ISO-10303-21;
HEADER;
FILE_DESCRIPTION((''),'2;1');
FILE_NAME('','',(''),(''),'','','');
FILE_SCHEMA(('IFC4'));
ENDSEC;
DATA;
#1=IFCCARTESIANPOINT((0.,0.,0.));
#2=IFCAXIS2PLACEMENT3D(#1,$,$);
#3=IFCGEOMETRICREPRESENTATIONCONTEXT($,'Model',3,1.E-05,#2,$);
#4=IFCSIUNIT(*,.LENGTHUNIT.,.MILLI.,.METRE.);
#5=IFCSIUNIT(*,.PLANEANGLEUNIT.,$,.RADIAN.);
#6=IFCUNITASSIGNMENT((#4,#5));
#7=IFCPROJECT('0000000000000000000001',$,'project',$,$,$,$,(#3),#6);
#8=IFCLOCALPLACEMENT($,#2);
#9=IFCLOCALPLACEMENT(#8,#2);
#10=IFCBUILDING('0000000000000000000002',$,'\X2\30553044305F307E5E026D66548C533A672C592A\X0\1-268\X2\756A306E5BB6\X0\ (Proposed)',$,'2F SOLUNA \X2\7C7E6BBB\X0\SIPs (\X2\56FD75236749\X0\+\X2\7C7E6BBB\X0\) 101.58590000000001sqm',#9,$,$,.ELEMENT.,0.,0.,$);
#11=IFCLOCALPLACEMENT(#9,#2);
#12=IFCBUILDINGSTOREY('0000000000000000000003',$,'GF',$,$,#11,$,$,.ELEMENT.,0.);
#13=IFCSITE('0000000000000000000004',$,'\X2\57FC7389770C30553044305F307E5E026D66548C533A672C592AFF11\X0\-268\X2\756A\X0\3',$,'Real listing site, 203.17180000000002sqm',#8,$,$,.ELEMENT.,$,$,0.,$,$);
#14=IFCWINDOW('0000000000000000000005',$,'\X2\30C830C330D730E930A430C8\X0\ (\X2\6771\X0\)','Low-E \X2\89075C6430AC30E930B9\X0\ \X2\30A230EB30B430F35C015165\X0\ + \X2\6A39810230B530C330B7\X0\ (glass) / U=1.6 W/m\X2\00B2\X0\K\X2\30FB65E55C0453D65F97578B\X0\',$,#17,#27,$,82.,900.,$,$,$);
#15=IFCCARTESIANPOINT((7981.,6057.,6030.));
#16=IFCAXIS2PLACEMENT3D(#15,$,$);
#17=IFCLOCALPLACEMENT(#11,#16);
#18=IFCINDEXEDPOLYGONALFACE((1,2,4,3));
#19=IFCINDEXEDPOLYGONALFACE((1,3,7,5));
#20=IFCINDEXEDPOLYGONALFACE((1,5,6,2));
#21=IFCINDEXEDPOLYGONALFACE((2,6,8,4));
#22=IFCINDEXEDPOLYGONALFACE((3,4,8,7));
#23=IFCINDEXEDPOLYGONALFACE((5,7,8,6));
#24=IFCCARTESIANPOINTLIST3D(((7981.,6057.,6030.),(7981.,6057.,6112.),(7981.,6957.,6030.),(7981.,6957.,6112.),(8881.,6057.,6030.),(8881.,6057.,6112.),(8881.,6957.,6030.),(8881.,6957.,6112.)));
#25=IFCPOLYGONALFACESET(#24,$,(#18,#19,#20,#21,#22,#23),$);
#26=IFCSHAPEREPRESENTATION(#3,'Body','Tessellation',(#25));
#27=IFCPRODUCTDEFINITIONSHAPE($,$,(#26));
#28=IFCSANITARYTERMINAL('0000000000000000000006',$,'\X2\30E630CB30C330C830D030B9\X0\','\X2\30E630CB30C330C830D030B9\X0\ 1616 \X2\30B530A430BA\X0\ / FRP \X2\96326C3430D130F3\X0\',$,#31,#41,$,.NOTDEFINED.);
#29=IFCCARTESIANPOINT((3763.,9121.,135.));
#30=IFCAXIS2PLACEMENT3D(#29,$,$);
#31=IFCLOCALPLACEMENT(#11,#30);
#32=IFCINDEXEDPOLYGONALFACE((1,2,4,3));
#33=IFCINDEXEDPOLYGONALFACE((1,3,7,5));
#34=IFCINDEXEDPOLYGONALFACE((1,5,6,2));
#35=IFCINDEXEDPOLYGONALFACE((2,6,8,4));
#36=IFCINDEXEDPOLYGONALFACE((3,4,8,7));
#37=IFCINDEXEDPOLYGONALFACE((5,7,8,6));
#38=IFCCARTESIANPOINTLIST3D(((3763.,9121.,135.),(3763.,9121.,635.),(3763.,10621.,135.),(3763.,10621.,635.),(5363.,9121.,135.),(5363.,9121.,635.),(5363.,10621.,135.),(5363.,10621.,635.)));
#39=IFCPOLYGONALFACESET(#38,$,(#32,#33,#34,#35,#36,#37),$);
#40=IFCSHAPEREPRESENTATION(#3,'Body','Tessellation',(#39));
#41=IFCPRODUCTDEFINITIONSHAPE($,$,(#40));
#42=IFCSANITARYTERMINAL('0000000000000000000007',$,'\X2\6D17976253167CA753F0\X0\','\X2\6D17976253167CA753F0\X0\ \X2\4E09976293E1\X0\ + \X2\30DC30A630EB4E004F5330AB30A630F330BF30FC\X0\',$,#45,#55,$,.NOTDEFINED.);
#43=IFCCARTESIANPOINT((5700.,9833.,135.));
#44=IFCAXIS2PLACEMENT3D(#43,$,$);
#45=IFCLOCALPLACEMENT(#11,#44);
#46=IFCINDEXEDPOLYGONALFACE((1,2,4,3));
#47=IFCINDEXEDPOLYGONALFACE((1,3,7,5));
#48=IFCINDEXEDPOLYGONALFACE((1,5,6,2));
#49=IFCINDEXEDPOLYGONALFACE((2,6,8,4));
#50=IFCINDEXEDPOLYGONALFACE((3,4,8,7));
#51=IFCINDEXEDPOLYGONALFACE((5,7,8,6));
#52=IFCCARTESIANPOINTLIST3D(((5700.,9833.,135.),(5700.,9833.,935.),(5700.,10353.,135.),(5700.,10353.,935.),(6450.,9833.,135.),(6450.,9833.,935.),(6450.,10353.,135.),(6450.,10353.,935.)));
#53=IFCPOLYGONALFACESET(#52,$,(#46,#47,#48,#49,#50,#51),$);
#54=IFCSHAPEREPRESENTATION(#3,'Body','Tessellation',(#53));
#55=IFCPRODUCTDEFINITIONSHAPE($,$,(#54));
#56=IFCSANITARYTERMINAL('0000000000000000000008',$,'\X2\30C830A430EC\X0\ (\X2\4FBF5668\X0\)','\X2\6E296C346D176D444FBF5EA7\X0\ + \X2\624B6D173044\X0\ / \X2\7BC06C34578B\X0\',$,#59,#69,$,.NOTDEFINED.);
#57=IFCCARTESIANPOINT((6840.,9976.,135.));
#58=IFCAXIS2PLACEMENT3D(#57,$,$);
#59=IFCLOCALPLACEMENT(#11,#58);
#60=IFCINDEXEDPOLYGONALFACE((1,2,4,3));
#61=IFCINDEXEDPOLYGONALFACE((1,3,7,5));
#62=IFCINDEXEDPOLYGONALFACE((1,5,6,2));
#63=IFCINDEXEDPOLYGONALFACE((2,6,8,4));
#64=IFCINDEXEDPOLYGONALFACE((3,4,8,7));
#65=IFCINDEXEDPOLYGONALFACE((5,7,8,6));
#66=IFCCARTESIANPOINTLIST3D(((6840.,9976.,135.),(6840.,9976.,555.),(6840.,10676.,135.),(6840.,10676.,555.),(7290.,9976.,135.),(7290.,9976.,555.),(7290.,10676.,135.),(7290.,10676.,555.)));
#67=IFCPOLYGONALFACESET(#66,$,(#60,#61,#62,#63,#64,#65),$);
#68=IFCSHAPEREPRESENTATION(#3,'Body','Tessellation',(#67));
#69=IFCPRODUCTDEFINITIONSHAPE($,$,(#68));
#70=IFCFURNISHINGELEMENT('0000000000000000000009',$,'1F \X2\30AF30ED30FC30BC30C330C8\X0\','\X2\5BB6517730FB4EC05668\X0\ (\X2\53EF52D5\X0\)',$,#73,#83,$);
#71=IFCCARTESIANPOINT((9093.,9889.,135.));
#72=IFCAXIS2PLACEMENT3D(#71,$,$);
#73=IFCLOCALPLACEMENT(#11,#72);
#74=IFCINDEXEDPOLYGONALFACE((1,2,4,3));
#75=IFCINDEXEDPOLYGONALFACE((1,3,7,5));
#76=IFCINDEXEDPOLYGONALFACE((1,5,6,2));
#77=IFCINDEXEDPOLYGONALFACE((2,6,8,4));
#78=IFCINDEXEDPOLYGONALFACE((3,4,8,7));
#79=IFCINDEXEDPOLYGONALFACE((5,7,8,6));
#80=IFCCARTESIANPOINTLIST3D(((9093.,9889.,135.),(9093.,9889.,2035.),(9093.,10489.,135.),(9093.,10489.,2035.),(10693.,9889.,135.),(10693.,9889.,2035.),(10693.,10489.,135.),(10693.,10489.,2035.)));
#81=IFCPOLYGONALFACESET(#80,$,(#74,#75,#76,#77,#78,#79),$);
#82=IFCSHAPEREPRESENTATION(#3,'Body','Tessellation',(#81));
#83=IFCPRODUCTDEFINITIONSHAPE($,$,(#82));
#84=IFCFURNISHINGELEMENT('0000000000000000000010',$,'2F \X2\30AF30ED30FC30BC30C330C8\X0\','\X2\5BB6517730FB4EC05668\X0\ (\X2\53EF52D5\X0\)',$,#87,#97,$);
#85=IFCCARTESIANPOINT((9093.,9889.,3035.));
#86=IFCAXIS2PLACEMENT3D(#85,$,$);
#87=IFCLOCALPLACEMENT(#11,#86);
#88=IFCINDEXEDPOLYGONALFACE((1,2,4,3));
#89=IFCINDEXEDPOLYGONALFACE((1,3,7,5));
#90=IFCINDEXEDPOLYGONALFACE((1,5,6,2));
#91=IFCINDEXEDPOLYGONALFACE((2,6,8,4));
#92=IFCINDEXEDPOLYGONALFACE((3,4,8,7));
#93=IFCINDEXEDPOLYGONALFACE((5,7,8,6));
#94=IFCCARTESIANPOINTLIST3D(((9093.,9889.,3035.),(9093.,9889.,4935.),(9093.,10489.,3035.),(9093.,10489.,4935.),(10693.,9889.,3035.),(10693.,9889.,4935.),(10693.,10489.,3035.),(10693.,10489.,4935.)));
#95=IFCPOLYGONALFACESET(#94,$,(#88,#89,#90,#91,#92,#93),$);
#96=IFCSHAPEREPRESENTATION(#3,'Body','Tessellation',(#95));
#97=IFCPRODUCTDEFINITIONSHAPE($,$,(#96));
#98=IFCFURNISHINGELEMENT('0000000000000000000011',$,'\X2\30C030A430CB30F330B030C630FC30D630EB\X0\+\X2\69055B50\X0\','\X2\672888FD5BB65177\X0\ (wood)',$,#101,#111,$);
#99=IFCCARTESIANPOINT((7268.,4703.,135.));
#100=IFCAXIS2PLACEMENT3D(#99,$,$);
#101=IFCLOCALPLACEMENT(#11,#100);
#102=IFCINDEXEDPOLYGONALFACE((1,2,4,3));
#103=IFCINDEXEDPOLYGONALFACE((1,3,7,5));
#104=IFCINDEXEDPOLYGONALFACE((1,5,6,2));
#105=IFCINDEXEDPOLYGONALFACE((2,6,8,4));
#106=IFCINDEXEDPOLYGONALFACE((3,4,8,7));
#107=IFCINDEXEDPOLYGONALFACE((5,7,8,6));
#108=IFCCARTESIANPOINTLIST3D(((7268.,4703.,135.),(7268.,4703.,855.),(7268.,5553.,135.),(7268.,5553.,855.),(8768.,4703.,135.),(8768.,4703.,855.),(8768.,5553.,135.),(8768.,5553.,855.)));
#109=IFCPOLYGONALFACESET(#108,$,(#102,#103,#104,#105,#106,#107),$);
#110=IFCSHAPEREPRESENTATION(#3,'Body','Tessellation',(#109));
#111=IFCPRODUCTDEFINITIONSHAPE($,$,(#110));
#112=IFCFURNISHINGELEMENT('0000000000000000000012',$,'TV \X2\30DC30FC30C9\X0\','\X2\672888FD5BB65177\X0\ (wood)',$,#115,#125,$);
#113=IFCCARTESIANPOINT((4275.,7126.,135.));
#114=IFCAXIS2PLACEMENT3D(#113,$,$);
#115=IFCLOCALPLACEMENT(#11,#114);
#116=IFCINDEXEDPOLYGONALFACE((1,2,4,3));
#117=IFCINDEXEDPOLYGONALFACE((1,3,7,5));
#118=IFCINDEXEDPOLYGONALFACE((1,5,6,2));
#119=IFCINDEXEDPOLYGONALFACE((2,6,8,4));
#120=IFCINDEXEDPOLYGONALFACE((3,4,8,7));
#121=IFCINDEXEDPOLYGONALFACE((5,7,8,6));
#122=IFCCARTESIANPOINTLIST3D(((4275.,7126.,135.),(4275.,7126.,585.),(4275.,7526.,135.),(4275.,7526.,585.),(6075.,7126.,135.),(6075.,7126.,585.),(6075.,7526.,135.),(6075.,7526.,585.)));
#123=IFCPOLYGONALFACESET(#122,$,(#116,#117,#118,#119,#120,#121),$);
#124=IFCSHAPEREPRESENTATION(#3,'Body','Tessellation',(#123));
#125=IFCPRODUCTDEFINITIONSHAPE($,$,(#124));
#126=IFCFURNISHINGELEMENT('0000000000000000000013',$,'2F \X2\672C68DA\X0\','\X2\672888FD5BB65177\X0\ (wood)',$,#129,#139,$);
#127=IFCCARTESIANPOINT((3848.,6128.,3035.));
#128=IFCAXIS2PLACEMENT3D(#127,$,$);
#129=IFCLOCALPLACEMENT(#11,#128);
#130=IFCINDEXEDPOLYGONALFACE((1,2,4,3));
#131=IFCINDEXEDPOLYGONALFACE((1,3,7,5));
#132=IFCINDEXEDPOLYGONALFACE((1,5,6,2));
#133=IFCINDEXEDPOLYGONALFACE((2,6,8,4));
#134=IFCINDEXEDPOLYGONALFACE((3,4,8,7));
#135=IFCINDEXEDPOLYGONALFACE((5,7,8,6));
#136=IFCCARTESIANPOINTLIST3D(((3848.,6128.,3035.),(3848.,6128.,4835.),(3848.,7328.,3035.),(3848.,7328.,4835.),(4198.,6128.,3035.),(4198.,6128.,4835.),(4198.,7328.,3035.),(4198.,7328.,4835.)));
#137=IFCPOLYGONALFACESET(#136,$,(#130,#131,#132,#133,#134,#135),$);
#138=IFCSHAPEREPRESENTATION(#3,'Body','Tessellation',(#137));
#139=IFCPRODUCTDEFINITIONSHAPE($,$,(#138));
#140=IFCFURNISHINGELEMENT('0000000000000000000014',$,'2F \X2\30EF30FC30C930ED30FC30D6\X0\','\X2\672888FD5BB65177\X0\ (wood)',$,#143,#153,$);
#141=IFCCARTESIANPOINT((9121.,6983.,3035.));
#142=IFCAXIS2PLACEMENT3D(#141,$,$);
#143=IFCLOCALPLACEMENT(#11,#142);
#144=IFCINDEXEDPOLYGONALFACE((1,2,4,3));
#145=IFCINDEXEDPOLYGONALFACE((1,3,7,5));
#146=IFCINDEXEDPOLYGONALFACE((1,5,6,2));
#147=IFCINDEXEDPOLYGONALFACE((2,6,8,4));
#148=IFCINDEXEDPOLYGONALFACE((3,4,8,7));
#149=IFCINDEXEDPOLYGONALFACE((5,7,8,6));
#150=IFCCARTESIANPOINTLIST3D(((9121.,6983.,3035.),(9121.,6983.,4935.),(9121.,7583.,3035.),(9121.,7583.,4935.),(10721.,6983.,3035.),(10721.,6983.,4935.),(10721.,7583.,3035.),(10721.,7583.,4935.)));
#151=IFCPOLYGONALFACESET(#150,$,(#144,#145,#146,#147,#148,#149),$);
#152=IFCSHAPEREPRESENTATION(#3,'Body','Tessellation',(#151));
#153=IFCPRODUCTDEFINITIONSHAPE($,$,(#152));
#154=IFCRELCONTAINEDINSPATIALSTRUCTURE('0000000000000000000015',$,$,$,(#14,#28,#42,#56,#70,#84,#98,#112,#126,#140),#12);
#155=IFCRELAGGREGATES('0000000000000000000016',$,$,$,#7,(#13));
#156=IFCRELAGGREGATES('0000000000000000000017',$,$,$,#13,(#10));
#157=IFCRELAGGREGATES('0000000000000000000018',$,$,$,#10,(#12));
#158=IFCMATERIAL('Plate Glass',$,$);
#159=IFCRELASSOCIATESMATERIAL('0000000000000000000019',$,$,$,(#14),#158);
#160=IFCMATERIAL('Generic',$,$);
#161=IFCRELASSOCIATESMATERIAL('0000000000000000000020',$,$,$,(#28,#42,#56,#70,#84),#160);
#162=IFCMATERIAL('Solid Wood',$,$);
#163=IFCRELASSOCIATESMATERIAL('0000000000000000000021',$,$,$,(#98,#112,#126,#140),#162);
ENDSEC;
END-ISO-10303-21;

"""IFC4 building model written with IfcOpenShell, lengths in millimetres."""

from ifc_helpers import new_model, si_unit, frame, frame_2d, origin, place, context, project, spatial, rectangle, extrude, material, element, save


model = new_model("IFC4")

# Units and contexts
model_context = context("Model", 3, precision=1e-05, world=origin())
ifc_project = project(units=[si_unit("LENGTHUNIT", "METRE", prefix="MILLI"), si_unit("PLANEANGLEUNIT", "RADIAN")], contexts=[model_context])

# Site, building, storey
site_placement = place(None, origin())
site = spatial("IfcSite", under=ifc_project, at=site_placement, Name="埼玉県さいたま市浦和区本太１-268番3", ObjectType="Real listing site, 203.17180000000002sqm", CompositionType="ELEMENT", RefElevation=0.0)
building_placement = place(site_placement, origin())
building = spatial("IfcBuilding", under=site, at=building_placement, Name="さいたま市浦和区本太1-268番の家 (Proposed)", ObjectType="2F SOLUNA 籾殻SIPs (国産杉+籾殻) 101.58590000000001sqm", CompositionType="ELEMENT", ElevationOfRefHeight=0.0, ElevationOfTerrain=0.0)
storey_placement = place(building_placement, origin())
storey = spatial("IfcBuildingStorey", under=building, at=storey_placement, Name="GF", CompositionType="ELEMENT", Elevation=0.0)

# Shared definitions
ifc_material_1 = material(Name="Solid Wood")
ifc_material_2 = material(Name="Plate Glass")

# Window
window_1_placement = place(storey_placement, frame((7981.0, 6057.0, 6030.0)))
element("IfcWindow", 1, at=window_1_placement, inside=storey, material=ifc_material_2, Name="トップライト (東)", Description="Low-E 複層ガラス アルゴン封入 + 樹脂サッシ (glass) / U=1.6 W/m²K・日射取得型", OverallHeight=82.0, OverallWidth=900.0, context=model_context, shape_type="SweptSolid", body=[
    extrude(rectangle(XDim=900.0, YDim=900.0, at=frame_2d((450.0, 450.0))), frame((7981.0, 6057.0, 6030.0)), (0.0, 0.0, 1.0), 82.0),
])

# Sanitary terminals
ifc_material_3 = material(Name="Generic")
sanitary_terminal_1_placement = place(storey_placement, frame((3763.0, 9121.0, 135.0)))
element("IfcSanitaryTerminal", 2, at=sanitary_terminal_1_placement, inside=storey, material=ifc_material_3, Name="ユニットバス", Description="ユニットバス 1616 サイズ / FRP 防水パン", PredefinedType="NOTDEFINED", context=model_context, shape_type="SweptSolid", body=[
    extrude(rectangle(XDim=1600.0, YDim=1500.0, at=frame_2d((800.0, 750.0))), frame((3763.0, 9121.0, 135.0)), (0.0, 0.0, 1.0), 500.0),
])
sanitary_terminal_2_placement = place(storey_placement, frame((5700.0, 9833.0, 135.0)))
element("IfcSanitaryTerminal", 3, at=sanitary_terminal_2_placement, inside=storey, material=ifc_material_3, Name="洗面化粧台", Description="洗面化粧台 三面鏡 + ボウル一体カウンター", PredefinedType="NOTDEFINED", context=model_context, shape_type="SweptSolid", body=[
    extrude(rectangle(XDim=750.0, YDim=520.0, at=frame_2d((375.0, 260.0))), frame((5700.0, 9833.0, 135.0)), (0.0, 0.0, 1.0), 800.0),
])
sanitary_terminal_3_placement = place(storey_placement, frame((6840.0, 9976.0, 135.0)))
element("IfcSanitaryTerminal", 4, at=sanitary_terminal_3_placement, inside=storey, material=ifc_material_3, Name="トイレ (便器)", Description="温水洗浄便座 + 手洗い / 節水型", PredefinedType="NOTDEFINED", context=model_context, shape_type="SweptSolid", body=[
    extrude(rectangle(XDim=450.0, YDim=700.0, at=frame_2d((225.0, 350.0))), frame((6840.0, 9976.0, 135.0)), (0.0, 0.0, 1.0), 420.0),
])

# Furnishing elements
furnishing_1_placement = place(storey_placement, frame((9093.0, 9889.0, 135.0)))
element("IfcFurnishingElement", 5, at=furnishing_1_placement, inside=storey, material=ifc_material_3, Name="1F クローゼット", Description="家具・什器 (可動)", context=model_context, shape_type="SweptSolid", body=[
    extrude(rectangle(XDim=1600.0, YDim=600.0, at=frame_2d((800.0, 300.0))), frame((9093.0, 9889.0, 135.0)), (0.0, 0.0, 1.0), 1900.0),
])
furnishing_2_placement = place(storey_placement, frame((9093.0, 9889.0, 3035.0)))
element("IfcFurnishingElement", 6, at=furnishing_2_placement, inside=storey, material=ifc_material_3, Name="2F クローゼット", Description="家具・什器 (可動)", context=model_context, shape_type="SweptSolid", body=[
    extrude(rectangle(XDim=1600.0, YDim=600.0, at=frame_2d((800.0, 300.0))), frame((9093.0, 9889.0, 3035.0)), (0.0, 0.0, 1.0), 1900.0),
])
furnishing_3_placement = place(storey_placement, frame((7268.0, 4703.0, 135.0)))
element("IfcFurnishingElement", 7, at=furnishing_3_placement, inside=storey, material=ifc_material_1, Name="ダイニングテーブル+椅子", Description="木製家具 (wood)", context=model_context, shape_type="SweptSolid", body=[
    extrude(rectangle(XDim=1500.0, YDim=850.0, at=frame_2d((750.0, 425.0))), frame((7268.0, 4703.0, 135.0)), (0.0, 0.0, 1.0), 720.0),
])
furnishing_4_placement = place(storey_placement, frame((4275.0, 7126.0, 135.0)))
element("IfcFurnishingElement", 8, at=furnishing_4_placement, inside=storey, material=ifc_material_1, Name="TV ボード", Description="木製家具 (wood)", context=model_context, shape_type="SweptSolid", body=[
    extrude(rectangle(XDim=1800.0, YDim=400.0, at=frame_2d((900.0, 200.0))), frame((4275.0, 7126.0, 135.0)), (0.0, 0.0, 1.0), 450.0),
])
furnishing_5_placement = place(storey_placement, frame((3848.0, 6128.0, 3035.0)))
element("IfcFurnishingElement", 9, at=furnishing_5_placement, inside=storey, material=ifc_material_1, Name="2F 本棚", Description="木製家具 (wood)", context=model_context, shape_type="SweptSolid", body=[
    extrude(rectangle(XDim=350.0, YDim=1200.0, at=frame_2d((175.0, 600.0))), frame((3848.0, 6128.0, 3035.0)), (0.0, 0.0, 1.0), 1800.0),
])
furnishing_6_placement = place(storey_placement, frame((9121.0, 6983.0, 3035.0)))
element("IfcFurnishingElement", 10, at=furnishing_6_placement, inside=storey, material=ifc_material_1, Name="2F ワードローブ", Description="木製家具 (wood)", context=model_context, shape_type="SweptSolid", body=[
    extrude(rectangle(XDim=1600.0, YDim=600.0, at=frame_2d((800.0, 300.0))), frame((9121.0, 6983.0, 3035.0)), (0.0, 0.0, 1.0), 1900.0),
])

save(model, "model.ifc")
